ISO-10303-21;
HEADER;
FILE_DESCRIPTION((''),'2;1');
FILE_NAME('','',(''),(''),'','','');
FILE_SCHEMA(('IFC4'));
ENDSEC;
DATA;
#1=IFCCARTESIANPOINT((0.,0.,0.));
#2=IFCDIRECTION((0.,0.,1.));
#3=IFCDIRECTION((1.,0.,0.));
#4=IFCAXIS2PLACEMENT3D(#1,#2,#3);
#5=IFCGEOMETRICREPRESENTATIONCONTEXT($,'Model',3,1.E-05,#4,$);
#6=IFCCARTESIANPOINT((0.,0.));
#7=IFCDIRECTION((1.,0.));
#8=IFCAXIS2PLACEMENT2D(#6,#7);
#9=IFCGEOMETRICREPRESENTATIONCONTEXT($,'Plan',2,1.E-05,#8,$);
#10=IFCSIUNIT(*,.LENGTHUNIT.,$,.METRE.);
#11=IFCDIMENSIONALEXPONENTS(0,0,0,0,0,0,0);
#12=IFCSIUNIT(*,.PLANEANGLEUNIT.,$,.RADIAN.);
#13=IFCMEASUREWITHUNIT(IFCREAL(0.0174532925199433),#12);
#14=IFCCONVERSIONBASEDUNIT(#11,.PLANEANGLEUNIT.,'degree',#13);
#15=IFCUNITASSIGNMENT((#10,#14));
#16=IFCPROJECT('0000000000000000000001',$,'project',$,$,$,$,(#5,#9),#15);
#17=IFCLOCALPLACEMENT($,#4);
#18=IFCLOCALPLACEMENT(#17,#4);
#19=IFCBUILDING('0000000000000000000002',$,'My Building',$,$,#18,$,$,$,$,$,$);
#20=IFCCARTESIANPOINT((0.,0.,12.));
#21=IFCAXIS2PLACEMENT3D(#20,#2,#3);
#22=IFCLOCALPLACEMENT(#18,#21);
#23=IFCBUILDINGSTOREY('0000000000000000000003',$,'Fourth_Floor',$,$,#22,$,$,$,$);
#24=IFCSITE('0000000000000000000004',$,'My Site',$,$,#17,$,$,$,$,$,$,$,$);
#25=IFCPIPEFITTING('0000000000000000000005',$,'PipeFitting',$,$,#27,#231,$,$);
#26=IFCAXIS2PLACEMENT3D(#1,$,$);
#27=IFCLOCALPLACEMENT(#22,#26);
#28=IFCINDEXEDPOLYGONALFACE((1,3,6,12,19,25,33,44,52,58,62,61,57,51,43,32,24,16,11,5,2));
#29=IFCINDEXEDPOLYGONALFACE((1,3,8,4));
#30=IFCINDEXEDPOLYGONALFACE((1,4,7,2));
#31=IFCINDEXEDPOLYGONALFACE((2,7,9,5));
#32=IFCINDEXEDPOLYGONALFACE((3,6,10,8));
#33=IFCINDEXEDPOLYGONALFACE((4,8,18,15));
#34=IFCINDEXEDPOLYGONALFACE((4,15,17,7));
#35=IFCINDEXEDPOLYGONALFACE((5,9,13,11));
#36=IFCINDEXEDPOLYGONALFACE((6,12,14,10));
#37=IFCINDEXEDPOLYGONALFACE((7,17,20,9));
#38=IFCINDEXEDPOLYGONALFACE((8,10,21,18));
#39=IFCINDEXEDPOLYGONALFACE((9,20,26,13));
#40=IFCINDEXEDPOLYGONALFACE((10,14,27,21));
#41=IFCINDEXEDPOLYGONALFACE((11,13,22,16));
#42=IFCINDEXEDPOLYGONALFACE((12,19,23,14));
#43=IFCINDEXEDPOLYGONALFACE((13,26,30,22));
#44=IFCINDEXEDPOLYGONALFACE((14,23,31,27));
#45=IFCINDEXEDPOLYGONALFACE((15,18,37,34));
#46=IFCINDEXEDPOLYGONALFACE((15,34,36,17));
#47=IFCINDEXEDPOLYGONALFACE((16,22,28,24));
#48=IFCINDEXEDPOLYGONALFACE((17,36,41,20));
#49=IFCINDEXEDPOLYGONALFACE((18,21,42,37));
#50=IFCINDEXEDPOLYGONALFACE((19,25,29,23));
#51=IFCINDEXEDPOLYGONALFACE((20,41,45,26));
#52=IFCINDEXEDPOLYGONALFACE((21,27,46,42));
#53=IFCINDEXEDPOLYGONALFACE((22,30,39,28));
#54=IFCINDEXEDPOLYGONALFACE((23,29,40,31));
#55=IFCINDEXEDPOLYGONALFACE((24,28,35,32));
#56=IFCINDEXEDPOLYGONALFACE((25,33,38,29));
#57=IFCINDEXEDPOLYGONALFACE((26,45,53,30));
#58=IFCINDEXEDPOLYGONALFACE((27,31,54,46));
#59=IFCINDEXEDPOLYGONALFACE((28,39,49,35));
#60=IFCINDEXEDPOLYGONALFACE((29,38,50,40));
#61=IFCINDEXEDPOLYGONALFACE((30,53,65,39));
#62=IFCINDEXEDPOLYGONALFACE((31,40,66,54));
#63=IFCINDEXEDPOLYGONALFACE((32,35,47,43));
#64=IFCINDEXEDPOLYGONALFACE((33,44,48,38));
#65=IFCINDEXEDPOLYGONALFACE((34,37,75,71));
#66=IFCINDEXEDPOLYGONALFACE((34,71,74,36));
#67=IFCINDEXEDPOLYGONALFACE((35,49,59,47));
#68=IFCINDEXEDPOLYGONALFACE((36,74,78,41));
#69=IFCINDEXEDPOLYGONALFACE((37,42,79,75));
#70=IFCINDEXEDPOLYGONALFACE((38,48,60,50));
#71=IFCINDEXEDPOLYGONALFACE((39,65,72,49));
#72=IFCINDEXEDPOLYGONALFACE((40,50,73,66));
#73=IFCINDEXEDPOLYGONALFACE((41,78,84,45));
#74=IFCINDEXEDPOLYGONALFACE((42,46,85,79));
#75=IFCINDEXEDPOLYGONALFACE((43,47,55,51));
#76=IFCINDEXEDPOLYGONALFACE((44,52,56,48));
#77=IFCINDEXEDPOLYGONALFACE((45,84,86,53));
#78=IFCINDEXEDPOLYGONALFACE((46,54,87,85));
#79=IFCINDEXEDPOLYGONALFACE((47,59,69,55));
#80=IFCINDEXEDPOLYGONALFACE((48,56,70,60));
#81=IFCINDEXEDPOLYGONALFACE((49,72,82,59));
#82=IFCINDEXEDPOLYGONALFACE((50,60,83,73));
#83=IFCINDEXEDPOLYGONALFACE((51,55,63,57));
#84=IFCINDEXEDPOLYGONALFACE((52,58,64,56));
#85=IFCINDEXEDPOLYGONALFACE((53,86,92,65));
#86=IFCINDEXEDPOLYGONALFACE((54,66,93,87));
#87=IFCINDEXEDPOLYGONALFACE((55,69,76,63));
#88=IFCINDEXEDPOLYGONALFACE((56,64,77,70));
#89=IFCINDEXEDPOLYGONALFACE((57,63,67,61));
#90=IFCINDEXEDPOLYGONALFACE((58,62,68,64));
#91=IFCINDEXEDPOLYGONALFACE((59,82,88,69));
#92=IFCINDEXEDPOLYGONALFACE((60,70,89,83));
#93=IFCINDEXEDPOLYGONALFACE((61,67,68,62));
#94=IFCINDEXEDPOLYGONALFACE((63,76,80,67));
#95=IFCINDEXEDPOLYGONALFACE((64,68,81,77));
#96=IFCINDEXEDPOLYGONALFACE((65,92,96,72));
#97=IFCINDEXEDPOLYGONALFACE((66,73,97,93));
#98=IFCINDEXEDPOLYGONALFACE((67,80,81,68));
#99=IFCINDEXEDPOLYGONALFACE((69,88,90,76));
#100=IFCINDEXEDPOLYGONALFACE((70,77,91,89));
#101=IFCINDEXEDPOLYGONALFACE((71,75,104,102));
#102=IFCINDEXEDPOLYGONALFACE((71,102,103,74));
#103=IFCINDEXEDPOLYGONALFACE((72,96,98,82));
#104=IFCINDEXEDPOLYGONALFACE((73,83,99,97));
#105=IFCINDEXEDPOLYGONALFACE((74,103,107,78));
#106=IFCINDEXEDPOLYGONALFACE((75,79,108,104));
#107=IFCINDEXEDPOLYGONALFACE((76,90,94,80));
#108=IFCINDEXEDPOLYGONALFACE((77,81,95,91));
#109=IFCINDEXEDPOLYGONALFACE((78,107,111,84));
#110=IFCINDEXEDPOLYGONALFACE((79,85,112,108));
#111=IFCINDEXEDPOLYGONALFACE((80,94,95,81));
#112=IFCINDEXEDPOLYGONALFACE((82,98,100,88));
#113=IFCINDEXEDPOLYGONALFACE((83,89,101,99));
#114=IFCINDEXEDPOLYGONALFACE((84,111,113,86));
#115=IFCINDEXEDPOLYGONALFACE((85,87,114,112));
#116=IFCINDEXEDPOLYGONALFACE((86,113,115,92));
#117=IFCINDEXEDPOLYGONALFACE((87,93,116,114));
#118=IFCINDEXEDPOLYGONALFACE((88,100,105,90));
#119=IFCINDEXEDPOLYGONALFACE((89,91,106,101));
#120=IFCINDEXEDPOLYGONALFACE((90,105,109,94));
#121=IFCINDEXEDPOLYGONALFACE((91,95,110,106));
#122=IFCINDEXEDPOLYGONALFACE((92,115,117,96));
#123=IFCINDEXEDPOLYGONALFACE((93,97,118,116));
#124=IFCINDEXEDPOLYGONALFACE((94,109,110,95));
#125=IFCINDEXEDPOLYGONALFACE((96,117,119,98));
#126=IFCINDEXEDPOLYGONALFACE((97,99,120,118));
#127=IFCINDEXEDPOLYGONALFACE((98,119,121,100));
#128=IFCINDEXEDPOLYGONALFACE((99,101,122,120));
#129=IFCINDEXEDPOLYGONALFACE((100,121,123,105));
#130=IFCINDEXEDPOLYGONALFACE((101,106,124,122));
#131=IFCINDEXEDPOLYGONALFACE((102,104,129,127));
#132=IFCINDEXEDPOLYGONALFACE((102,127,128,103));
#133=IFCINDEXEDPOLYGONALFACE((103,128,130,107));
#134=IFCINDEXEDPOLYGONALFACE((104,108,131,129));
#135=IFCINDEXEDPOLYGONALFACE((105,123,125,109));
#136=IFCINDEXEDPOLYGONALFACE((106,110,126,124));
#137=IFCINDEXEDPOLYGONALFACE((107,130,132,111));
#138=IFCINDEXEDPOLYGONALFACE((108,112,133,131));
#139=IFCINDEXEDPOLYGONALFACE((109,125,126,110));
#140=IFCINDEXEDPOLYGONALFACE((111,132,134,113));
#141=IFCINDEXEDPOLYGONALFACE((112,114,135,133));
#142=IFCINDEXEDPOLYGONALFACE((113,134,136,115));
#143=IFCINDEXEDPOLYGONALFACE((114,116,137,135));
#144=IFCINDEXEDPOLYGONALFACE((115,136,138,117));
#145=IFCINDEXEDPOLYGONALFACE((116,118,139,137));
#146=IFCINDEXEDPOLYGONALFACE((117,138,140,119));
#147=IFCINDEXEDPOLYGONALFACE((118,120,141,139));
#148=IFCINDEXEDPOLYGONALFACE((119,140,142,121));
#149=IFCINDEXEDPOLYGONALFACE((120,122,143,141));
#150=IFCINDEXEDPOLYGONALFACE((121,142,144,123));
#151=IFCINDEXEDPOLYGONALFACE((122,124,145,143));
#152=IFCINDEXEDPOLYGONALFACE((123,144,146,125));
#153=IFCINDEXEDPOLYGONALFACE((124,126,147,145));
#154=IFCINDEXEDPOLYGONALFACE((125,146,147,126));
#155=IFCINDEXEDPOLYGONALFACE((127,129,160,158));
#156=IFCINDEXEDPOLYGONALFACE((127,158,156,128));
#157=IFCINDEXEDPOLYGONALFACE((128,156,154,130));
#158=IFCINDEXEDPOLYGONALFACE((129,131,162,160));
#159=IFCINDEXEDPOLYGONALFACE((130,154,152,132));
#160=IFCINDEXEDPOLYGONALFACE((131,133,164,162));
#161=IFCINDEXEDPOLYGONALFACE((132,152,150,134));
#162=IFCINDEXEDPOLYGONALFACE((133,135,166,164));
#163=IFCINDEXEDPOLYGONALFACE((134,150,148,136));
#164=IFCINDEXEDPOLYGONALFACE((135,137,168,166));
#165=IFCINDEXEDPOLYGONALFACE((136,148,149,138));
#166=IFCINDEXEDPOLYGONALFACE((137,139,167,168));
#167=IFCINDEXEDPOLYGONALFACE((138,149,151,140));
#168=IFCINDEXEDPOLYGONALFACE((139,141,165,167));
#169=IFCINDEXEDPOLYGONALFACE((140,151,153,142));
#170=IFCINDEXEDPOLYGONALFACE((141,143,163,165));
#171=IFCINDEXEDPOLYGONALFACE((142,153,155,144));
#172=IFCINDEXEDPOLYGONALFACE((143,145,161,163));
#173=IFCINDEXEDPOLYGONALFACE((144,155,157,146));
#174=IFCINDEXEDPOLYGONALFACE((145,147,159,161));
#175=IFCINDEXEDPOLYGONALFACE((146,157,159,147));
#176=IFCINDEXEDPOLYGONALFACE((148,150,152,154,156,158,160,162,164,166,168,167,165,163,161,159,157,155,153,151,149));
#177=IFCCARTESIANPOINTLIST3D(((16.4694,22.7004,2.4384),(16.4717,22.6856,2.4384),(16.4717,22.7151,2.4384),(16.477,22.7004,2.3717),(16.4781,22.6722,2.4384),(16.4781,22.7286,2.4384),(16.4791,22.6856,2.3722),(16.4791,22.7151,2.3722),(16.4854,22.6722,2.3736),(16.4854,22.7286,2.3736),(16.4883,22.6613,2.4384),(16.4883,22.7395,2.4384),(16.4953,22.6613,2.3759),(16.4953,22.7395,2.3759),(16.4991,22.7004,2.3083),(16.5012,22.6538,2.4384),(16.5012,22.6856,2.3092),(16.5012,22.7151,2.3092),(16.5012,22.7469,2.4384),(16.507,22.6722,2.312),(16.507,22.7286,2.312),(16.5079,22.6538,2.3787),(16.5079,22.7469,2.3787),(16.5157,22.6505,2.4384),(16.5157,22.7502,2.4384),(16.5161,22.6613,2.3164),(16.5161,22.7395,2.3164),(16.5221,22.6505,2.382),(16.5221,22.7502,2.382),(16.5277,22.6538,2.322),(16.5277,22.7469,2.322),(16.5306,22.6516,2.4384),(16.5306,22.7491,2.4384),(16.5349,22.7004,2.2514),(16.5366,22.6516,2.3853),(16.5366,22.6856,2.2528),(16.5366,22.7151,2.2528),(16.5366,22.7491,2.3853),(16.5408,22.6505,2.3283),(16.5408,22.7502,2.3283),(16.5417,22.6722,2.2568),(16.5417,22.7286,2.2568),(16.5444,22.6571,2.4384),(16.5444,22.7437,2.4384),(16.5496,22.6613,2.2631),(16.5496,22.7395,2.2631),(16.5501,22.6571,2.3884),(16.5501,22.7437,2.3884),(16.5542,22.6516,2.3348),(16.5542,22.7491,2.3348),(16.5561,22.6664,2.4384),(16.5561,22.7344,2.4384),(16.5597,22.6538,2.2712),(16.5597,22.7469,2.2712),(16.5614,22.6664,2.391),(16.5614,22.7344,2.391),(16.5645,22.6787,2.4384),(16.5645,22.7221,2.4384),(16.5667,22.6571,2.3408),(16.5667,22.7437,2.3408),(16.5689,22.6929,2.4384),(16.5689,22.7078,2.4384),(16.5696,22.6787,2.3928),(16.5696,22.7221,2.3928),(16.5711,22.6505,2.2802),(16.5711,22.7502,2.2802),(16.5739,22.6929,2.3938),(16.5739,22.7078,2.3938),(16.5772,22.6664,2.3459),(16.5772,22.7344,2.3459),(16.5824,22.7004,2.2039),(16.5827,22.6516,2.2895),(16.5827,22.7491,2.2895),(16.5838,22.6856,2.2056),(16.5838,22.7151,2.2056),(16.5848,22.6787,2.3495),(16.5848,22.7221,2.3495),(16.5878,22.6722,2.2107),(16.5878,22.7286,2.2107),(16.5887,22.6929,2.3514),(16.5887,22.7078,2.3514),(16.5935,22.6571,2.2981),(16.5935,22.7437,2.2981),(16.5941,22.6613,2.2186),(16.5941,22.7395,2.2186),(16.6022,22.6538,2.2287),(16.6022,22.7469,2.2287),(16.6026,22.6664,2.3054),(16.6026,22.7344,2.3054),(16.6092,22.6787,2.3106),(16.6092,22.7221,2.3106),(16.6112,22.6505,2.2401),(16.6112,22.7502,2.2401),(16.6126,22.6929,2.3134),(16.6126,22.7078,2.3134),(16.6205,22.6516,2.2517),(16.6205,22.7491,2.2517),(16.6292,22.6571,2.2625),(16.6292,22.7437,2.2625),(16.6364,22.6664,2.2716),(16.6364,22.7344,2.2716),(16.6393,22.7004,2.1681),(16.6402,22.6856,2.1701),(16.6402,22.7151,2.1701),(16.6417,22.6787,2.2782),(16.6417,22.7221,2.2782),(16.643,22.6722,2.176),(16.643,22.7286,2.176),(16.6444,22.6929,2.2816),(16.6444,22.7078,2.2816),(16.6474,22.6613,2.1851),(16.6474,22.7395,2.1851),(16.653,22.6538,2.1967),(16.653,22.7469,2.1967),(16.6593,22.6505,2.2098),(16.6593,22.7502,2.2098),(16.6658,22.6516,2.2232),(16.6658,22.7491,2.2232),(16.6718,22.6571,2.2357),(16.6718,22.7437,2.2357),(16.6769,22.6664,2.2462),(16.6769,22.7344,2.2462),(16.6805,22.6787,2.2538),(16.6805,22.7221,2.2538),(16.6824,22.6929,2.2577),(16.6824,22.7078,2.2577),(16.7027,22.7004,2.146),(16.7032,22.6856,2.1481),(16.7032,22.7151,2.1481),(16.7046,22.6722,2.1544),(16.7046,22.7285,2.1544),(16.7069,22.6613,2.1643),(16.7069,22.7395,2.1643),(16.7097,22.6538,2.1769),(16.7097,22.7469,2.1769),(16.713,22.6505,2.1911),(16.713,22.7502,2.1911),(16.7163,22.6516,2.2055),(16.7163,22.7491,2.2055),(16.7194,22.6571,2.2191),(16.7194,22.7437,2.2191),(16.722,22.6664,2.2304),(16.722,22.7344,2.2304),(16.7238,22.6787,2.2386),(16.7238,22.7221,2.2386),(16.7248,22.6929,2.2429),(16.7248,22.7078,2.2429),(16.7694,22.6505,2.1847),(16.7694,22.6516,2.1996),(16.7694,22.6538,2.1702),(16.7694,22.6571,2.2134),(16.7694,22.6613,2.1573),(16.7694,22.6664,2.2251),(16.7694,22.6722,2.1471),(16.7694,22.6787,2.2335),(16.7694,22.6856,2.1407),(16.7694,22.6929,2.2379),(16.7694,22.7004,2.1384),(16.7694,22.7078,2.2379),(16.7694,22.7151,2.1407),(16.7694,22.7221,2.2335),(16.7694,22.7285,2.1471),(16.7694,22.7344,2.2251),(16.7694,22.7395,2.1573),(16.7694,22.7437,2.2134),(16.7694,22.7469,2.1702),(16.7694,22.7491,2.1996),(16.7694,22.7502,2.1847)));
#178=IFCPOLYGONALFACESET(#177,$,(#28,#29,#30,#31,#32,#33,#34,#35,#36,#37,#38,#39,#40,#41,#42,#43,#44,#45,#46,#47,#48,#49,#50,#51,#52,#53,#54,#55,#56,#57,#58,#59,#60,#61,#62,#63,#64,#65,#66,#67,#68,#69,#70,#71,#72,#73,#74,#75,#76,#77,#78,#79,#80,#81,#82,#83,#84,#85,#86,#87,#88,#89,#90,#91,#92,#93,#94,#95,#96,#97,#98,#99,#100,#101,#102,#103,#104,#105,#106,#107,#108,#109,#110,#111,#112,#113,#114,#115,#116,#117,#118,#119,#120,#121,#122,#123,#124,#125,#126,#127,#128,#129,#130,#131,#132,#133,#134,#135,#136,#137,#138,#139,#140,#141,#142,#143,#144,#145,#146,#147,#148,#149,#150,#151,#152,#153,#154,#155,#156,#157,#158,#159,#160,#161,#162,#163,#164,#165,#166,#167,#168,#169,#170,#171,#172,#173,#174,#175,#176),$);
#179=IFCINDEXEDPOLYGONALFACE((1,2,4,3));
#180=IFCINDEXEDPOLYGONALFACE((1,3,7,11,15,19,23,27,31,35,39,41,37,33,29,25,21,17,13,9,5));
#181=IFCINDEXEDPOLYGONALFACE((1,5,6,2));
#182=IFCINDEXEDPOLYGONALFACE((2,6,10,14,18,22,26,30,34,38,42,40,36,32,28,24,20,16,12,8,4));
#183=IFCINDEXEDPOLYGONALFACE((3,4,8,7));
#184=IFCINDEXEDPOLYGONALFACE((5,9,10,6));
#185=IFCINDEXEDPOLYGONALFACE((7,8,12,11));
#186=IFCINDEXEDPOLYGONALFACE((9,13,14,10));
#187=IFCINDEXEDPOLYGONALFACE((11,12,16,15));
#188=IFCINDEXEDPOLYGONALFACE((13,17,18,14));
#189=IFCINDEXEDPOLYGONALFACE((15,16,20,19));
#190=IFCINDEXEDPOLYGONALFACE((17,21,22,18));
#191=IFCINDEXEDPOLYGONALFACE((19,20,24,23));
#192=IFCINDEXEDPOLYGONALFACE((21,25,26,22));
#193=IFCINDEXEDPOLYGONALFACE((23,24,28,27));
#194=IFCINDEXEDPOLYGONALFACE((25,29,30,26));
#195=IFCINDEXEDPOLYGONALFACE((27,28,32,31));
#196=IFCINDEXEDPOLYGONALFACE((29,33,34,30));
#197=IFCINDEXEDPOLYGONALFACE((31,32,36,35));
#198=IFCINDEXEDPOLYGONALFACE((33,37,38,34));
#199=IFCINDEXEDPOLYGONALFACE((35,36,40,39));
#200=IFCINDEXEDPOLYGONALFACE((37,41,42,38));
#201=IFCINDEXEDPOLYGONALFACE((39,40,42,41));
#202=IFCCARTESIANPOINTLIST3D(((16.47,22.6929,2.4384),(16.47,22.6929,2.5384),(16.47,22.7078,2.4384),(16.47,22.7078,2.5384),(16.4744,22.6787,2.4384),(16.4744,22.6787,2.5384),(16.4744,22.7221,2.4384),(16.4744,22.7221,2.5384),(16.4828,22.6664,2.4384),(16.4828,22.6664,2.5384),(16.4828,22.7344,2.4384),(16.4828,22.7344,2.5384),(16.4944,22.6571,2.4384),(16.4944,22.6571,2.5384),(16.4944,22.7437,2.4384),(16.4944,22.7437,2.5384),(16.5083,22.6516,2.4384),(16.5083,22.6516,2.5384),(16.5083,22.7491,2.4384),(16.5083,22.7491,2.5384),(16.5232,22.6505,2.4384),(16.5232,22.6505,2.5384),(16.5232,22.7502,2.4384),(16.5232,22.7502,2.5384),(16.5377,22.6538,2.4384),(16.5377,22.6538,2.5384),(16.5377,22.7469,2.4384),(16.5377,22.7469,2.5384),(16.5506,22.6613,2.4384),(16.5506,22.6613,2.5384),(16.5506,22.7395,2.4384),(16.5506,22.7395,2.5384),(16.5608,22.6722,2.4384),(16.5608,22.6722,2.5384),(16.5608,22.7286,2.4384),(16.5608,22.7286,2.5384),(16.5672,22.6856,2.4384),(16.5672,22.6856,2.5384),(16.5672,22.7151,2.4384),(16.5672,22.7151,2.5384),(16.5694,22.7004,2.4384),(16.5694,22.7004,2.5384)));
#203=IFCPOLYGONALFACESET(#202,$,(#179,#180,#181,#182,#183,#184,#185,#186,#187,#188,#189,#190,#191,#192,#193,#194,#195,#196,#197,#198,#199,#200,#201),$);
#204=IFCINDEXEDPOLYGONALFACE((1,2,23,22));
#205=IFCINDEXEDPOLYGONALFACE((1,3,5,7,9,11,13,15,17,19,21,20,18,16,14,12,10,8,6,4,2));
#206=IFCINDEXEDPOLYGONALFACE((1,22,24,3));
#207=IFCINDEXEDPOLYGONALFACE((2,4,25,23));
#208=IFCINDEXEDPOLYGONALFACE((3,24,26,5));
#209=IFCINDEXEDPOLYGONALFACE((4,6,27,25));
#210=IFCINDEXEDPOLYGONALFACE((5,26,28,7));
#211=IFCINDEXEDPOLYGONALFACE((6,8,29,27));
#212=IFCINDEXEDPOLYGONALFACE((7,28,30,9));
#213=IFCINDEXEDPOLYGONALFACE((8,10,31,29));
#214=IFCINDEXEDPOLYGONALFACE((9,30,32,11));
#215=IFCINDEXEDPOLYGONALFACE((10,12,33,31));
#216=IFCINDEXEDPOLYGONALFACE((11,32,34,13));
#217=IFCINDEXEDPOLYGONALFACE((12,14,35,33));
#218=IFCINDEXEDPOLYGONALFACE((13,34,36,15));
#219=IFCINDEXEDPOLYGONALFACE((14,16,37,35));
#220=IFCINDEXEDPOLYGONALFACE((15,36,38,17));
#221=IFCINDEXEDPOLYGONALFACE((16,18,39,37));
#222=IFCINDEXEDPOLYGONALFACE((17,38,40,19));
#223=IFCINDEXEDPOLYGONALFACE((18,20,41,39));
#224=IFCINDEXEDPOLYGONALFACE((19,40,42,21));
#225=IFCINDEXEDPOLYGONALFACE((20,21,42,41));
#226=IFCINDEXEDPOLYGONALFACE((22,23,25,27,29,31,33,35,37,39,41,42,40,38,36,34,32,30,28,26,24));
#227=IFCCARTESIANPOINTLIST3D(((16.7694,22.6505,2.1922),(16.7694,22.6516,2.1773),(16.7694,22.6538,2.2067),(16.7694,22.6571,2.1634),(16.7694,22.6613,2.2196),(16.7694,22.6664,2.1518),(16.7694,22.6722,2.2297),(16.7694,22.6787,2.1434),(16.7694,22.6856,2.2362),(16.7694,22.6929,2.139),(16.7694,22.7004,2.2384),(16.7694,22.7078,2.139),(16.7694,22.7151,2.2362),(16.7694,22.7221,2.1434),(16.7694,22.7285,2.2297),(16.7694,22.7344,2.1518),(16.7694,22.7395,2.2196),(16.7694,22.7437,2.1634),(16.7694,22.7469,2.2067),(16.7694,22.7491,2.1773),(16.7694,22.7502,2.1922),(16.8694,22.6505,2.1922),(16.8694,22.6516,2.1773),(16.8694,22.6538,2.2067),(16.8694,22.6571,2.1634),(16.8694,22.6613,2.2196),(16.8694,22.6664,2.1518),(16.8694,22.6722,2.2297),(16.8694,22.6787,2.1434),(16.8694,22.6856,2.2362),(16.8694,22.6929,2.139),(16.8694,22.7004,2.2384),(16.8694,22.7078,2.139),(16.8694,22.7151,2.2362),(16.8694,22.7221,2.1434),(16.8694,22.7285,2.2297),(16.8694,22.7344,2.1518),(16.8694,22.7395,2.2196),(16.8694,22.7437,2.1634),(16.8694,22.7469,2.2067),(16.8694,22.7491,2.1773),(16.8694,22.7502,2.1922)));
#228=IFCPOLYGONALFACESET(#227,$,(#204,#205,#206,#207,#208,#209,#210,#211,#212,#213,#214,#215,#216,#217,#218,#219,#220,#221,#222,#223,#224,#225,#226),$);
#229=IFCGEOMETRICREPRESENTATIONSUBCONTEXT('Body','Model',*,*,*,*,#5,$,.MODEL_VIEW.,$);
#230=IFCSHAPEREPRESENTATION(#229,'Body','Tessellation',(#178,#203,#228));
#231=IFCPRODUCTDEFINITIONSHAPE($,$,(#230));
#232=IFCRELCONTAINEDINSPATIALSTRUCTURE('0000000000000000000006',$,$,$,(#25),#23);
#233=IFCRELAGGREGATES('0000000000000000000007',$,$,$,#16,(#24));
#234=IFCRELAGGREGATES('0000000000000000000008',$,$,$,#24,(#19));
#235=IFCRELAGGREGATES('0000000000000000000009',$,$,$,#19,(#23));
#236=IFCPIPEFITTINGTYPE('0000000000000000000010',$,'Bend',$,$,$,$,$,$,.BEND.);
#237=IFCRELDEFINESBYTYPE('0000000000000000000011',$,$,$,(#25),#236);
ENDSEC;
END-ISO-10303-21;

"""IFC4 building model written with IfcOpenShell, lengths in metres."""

from ifc_helpers import new_model, entity, si_unit, converted_unit, frame, origin_with_axes, origin_2d_with_axis, place, context, subcontext, project, spatial, circle, extrude, source, transform, mapped, type_object, type_shapes, element, save


model = new_model("IFC4")

# Units and contexts
model_context = context("Model", 3, precision=1e-05, world=origin_with_axes())
plan_context = context("Plan", 2, precision=1e-05, world=origin_2d_with_axis())
body_context = subcontext(model_context, "Body", "Model", "MODEL_VIEW")
ifc_project = project(units=[si_unit("LENGTHUNIT", "METRE"), converted_unit("PLANEANGLEUNIT", "degree", entity("IfcReal", 0.0174532925199433), si_unit("PLANEANGLEUNIT", "RADIAN"), dimensions=[0, 0, 0, 0, 0, 0, 0])], contexts=[model_context, plan_context])

# Site, building, storey
site_placement = place(None, origin_with_axes())
site = spatial("IfcSite", under=ifc_project, at=site_placement, Name="My Site")
building_placement = place(site_placement, origin_with_axes())
building = spatial("IfcBuilding", under=site, at=building_placement, Name="My Building")
storey_placement = place(building_placement, frame((0.0, 0.0, 12.0), z_axis=(0.0, 0.0, 1.0), x_axis=(1.0, 0.0, 0.0)))
storey = spatial("IfcBuildingStorey", under=building, at=storey_placement, Name="Fourth_Floor")

# Pipe fitting
pipe_fitting_type = type_object("IfcPipeFittingType", Name="Bend", PredefinedType="BEND")
shared_shape = source(origin_with_axes(), body_context, "Body", "SolidModel", [
    entity("IfcSweptDiskSolid", entity("IfcIndexedPolyCurve", entity("IfcCartesianPointList3D", [[0.0, 0.0, -0.1], [0.0732, 0.0, -0.2768], [0.25, 0.0, -0.35]]), [entity("IfcArcIndex", [1, 2, 3])]), 0.05),
    extrude(circle(Radius=0.05), origin_with_axes(), (0.0, 0.0, -1.0), 0.1),
    extrude(circle(Radius=0.05), frame((0.25, 0.0, -0.35), z_axis=(1.0, 0.0, 0.0), x_axis=(0.0, 0.0, 1.0)), (0.0, 0.0, 1.0), 0.1),
])
type_shapes(pipe_fitting_type, [shared_shape])
for number, where, z_axis, x_axis, name in (
    (1, (16.5194, 22.7004, 2.5384), (0.0, 0.0, 1.0), (1.0, 0.0, 0.0), "PipeFitting"),
):
    element("IfcPipeFitting", number, at=place(storey_placement, frame(where, z_axis=z_axis, x_axis=x_axis)), inside=storey, type_object=pipe_fitting_type, Name=name, context=body_context, shape_type="MappedRepresentation", body=[
        mapped(shared_shape, transform((0.0, 0.0, 0.0), x_axis=(1.0, 0.0, 0.0), y_axis=(0.0, 1.0, 0.0), z_axis=(0.0, 0.0, 1.0), scale=1.0)),
    ])

save(model, "model.ifc")
